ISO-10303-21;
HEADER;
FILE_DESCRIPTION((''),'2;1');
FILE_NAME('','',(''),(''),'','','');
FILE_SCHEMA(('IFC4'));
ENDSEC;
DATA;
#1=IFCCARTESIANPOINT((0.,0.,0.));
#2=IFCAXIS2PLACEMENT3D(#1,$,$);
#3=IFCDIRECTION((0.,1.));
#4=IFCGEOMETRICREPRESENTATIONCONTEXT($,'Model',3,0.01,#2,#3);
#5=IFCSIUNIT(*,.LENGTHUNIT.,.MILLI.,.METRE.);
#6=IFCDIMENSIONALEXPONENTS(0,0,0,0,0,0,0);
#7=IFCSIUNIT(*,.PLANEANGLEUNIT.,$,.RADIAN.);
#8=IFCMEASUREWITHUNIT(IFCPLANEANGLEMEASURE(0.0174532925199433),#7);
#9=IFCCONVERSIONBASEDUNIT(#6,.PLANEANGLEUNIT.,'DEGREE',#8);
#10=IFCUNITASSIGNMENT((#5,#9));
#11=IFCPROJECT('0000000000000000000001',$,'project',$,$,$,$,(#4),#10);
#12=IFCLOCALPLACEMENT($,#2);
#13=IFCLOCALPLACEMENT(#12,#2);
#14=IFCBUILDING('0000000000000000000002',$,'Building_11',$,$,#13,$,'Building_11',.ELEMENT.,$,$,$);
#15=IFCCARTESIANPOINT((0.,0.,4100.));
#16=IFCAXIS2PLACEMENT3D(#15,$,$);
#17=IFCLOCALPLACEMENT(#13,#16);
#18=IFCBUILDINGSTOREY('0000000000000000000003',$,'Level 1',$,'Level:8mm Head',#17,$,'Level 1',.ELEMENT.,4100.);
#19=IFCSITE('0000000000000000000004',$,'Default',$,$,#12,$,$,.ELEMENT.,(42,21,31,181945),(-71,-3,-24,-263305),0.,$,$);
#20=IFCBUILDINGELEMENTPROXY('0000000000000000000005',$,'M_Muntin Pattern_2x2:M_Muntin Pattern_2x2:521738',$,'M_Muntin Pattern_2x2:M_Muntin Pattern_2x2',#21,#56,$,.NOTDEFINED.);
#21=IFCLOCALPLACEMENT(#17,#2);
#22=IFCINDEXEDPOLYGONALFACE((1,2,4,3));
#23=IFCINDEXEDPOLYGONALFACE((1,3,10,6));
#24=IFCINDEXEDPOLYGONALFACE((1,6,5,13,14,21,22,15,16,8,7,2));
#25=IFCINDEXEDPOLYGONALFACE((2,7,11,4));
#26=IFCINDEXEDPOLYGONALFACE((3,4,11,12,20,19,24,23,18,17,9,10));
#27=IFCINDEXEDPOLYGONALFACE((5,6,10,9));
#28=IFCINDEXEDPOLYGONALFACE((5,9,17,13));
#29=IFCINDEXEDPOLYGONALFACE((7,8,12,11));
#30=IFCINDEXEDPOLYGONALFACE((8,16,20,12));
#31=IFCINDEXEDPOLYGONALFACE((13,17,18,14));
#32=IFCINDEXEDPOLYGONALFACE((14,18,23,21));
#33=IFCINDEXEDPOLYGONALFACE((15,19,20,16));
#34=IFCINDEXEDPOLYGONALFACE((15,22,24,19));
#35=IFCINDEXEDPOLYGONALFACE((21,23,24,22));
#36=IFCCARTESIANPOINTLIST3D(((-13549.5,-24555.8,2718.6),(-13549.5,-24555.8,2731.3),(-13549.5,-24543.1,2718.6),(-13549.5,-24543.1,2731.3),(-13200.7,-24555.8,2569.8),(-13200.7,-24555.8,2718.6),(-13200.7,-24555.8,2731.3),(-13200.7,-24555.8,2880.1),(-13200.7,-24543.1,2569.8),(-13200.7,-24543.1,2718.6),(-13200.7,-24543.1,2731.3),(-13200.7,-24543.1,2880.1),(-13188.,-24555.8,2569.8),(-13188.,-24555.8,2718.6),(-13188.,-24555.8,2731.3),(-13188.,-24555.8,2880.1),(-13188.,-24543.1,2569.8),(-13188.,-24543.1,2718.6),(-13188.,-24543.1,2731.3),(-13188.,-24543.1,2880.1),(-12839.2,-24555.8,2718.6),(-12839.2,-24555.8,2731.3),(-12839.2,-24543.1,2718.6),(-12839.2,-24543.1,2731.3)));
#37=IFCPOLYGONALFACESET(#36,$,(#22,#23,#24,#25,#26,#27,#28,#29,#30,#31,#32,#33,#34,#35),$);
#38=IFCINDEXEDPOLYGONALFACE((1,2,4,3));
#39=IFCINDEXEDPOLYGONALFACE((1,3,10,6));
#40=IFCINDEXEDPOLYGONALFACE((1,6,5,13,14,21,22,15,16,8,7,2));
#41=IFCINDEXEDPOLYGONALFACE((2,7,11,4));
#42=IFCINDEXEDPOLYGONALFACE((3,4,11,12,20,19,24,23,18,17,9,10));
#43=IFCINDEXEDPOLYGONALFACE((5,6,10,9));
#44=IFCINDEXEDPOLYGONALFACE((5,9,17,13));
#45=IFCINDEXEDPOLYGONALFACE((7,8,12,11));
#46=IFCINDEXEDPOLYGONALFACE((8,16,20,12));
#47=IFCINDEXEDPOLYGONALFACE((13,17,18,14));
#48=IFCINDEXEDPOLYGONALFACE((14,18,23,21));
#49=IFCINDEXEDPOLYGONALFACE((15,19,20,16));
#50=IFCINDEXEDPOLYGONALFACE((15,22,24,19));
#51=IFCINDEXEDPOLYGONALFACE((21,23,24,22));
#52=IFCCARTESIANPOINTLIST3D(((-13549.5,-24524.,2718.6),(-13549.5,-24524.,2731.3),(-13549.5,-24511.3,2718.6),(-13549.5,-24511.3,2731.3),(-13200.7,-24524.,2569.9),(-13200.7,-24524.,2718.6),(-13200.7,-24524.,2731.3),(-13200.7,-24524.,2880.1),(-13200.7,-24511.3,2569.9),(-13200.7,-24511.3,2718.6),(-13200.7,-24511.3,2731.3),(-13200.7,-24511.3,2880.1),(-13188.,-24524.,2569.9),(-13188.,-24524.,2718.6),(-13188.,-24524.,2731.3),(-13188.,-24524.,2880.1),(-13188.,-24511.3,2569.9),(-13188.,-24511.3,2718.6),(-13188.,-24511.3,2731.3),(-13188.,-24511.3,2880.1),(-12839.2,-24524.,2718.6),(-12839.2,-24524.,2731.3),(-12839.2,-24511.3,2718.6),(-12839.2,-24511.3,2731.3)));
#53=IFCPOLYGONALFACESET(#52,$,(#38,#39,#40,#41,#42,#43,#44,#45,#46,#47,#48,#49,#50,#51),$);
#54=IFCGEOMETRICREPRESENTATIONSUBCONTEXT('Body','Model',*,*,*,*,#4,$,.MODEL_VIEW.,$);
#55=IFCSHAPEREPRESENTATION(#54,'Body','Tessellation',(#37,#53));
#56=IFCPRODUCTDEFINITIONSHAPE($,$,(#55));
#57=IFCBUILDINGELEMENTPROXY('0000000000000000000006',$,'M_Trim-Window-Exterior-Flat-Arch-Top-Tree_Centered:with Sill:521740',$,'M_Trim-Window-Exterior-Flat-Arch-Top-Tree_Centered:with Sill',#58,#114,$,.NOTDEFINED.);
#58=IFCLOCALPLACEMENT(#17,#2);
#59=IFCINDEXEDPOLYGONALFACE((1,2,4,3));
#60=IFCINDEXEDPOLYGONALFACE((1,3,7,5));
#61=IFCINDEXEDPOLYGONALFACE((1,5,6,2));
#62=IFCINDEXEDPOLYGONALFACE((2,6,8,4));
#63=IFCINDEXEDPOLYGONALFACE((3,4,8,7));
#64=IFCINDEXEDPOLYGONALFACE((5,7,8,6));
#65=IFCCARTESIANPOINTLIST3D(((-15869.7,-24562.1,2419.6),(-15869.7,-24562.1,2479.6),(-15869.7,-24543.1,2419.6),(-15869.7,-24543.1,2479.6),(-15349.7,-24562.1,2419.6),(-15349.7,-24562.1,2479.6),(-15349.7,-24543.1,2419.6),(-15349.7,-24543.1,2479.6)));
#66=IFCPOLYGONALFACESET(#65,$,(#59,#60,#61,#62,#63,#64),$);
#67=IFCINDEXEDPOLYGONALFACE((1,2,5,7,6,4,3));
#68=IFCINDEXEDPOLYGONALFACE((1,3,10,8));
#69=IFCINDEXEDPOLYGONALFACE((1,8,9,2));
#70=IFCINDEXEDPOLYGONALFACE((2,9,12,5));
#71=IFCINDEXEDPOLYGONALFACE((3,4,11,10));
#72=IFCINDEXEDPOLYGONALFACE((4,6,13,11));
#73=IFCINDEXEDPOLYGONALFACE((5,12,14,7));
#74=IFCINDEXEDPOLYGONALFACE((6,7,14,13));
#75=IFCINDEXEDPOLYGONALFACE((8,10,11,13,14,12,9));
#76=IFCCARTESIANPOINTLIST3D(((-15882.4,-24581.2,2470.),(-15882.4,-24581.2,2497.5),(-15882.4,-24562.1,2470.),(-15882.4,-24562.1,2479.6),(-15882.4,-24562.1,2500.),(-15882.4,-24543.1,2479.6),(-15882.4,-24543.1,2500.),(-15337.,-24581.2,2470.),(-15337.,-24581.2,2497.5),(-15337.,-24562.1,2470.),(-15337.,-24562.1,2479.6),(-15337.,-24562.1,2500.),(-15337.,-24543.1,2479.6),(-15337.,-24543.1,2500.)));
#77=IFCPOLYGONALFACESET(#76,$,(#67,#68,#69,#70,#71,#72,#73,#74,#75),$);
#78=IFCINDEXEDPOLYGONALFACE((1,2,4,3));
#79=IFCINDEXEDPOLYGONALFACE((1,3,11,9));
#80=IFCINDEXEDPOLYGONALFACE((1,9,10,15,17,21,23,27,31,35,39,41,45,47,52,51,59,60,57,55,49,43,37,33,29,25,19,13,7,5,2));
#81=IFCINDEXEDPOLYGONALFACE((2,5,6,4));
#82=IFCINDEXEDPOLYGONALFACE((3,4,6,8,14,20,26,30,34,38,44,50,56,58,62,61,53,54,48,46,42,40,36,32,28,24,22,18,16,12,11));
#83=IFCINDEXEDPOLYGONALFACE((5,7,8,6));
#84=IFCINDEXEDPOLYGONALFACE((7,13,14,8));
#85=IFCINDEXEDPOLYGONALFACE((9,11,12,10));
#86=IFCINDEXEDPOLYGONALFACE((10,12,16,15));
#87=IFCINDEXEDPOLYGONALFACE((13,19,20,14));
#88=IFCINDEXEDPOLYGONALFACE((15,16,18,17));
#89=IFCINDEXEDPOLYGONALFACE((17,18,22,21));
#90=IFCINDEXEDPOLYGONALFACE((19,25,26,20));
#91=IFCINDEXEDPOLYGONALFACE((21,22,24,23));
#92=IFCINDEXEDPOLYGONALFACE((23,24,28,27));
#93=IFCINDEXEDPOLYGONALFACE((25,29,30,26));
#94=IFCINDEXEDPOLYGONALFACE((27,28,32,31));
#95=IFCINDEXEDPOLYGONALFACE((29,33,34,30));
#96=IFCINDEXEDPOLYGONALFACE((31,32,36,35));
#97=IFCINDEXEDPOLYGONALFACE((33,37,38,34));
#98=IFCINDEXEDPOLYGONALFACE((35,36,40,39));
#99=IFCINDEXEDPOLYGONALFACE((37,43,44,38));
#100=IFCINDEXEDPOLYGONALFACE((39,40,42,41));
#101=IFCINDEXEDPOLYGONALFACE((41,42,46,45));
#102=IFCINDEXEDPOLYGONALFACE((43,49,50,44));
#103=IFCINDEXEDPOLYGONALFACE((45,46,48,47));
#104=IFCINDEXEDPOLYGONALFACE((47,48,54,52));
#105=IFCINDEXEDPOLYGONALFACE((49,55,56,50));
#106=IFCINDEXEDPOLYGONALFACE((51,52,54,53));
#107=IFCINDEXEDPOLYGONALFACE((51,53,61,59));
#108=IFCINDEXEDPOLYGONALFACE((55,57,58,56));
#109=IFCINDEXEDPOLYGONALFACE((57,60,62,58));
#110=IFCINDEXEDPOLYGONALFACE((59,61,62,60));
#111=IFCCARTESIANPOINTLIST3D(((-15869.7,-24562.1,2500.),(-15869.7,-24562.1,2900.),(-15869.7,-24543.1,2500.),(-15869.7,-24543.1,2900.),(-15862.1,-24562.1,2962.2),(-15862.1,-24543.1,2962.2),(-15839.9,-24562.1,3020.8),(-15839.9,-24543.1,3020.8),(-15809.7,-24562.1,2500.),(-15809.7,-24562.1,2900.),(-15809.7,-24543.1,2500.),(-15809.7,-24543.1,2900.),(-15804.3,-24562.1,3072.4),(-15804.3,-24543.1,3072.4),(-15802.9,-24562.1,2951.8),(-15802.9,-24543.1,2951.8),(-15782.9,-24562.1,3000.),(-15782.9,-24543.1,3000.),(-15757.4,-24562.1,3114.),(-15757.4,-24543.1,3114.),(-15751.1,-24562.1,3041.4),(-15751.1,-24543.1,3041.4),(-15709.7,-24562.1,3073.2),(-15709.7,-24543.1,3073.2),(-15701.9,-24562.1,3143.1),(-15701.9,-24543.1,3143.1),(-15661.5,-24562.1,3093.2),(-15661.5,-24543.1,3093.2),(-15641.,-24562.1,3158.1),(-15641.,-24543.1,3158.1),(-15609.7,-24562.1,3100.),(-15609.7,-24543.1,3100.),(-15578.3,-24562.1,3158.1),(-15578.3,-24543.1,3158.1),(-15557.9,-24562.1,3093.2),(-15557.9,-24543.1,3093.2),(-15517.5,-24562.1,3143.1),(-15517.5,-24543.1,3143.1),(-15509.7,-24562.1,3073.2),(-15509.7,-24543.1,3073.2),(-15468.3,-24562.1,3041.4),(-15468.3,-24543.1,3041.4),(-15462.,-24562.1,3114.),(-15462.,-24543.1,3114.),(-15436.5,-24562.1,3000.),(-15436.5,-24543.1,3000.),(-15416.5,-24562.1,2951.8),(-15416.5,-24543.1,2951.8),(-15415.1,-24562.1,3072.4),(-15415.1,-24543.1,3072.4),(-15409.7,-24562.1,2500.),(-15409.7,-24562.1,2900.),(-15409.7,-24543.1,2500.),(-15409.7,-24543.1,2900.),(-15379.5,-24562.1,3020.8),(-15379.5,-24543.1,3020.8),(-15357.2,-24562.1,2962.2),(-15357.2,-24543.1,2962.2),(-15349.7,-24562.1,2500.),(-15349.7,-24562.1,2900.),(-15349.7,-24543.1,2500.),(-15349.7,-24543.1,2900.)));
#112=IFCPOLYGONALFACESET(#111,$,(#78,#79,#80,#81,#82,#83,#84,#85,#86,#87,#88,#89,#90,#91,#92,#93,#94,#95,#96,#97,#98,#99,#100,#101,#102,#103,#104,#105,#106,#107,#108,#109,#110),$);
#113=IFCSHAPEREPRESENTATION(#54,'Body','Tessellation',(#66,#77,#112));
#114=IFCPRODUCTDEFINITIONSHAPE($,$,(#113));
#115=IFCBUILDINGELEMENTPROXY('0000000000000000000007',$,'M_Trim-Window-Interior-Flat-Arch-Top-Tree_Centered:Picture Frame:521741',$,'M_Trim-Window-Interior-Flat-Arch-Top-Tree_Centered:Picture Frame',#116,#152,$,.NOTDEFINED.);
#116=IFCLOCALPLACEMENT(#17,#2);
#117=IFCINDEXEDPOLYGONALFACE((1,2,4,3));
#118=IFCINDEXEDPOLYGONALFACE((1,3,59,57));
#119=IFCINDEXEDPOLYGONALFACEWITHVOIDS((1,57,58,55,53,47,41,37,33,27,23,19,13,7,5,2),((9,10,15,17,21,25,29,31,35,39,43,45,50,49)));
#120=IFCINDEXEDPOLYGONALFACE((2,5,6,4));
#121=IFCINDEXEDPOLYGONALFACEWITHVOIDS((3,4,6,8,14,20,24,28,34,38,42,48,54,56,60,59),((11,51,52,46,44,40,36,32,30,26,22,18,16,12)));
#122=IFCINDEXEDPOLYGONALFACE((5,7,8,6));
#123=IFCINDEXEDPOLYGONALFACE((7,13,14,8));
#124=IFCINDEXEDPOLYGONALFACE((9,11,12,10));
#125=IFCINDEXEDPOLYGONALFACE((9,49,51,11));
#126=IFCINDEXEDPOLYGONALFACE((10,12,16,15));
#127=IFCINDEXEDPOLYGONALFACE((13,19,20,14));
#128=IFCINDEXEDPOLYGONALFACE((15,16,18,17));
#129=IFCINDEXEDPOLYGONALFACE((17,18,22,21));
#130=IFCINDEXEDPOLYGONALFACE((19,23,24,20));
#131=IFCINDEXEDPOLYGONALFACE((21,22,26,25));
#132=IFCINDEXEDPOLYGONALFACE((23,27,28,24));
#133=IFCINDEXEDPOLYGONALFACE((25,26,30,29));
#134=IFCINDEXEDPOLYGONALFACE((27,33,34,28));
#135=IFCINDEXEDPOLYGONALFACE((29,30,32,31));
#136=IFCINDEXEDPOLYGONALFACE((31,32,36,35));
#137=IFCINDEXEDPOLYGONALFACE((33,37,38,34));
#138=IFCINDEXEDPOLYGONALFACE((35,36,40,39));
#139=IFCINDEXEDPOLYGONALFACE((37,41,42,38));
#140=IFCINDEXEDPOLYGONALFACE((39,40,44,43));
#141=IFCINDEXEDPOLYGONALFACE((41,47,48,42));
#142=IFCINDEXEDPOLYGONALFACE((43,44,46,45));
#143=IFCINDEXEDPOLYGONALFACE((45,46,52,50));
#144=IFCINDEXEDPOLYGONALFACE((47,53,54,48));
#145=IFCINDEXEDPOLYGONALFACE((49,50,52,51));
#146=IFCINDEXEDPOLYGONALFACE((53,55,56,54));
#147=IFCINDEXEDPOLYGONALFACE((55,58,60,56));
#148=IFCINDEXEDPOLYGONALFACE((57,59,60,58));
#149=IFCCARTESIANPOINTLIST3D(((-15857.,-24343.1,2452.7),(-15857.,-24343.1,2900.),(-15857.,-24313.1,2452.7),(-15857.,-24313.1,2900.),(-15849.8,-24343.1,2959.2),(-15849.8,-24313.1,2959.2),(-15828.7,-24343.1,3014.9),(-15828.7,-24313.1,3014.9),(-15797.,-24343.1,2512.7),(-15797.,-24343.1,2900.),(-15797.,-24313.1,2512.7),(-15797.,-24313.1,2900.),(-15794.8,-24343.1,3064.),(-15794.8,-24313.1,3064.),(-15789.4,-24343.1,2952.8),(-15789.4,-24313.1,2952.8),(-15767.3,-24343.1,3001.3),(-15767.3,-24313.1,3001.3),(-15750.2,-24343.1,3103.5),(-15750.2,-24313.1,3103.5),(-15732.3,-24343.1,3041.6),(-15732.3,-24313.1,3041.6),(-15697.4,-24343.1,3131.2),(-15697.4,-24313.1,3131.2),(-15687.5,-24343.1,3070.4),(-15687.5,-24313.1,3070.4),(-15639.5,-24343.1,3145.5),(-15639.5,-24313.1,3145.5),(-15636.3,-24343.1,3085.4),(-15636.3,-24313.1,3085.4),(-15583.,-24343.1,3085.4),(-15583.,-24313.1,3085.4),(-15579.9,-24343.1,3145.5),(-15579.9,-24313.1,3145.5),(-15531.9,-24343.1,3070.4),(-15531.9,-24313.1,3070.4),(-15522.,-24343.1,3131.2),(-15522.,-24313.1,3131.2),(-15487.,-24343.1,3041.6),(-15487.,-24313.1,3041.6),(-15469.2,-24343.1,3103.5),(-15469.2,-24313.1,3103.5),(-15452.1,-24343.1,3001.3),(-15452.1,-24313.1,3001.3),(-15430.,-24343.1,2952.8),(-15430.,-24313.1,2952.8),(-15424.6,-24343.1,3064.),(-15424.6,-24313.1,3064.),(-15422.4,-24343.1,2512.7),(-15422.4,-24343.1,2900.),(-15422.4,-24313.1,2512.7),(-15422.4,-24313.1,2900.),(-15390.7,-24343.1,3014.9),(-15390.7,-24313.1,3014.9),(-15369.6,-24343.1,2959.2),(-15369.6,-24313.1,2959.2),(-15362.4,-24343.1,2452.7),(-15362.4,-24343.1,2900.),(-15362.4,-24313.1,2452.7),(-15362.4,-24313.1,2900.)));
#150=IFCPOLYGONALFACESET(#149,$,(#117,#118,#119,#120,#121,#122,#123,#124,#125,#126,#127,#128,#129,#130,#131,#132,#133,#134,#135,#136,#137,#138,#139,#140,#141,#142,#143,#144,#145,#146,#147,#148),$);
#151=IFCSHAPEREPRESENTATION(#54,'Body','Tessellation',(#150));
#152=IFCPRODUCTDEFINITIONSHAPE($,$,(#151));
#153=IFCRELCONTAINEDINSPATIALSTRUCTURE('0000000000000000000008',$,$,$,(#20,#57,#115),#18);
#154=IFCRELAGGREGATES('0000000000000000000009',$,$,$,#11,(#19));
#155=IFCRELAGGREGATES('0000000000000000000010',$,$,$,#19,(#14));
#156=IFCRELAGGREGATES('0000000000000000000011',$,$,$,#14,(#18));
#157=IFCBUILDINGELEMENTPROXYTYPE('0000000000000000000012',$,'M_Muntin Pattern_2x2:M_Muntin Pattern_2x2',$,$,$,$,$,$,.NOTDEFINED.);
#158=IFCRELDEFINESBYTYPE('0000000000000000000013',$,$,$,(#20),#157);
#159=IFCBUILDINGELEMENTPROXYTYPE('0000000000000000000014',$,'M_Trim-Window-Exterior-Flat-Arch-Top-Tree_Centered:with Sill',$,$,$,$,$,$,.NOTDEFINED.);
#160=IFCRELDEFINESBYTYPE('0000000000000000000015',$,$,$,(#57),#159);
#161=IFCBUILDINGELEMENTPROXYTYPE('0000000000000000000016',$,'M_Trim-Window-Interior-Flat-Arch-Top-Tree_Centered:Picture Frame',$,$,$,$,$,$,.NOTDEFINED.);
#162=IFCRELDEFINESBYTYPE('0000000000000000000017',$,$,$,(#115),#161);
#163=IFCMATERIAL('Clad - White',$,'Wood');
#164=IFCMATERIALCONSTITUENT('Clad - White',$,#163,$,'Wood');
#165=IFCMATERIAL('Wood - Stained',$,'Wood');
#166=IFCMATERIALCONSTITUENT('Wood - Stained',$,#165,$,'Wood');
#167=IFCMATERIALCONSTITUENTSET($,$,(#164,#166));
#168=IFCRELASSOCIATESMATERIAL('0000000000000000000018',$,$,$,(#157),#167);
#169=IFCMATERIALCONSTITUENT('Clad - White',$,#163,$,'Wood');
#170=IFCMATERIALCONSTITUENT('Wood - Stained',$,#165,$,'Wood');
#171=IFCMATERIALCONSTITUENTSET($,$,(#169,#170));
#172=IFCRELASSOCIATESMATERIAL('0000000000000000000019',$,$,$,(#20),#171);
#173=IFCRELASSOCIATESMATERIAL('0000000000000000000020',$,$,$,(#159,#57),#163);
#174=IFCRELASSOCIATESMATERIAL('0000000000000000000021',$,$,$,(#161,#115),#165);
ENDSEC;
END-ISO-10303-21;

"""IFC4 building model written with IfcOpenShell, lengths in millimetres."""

from ifc_helpers import new_model, entity, si_unit, converted_unit, direction, frame, origin, place, context, subcontext, project, spatial, line, arc, indexed_curve, outline, extrude, source, transform, mapped, material, constituent, constituent_set, type_object, type_shapes, element, save


model = new_model("IFC4")

# Units and contexts
model_context = context("Model", 3, precision=0.01, world=origin(), true_north=direction((0.0, 1.0)))
body_context = subcontext(model_context, "Body", "Model", "MODEL_VIEW")
ifc_project = project(units=[si_unit("LENGTHUNIT", "METRE", prefix="MILLI"), converted_unit("PLANEANGLEUNIT", "DEGREE", entity("IfcPlaneAngleMeasure", 0.0174532925199433), si_unit("PLANEANGLEUNIT", "RADIAN"), dimensions=[0, 0, 0, 0, 0, 0, 0])], contexts=[model_context])

# Site, building, storey
site_placement = place(None, origin())
site = spatial("IfcSite", under=ifc_project, at=site_placement, Name="Default", CompositionType="ELEMENT", RefLatitude=(42, 21, 31, 181945), RefLongitude=(-71, -3, -24, -263305), RefElevation=0.0)
building_placement = place(site_placement, origin())
building = spatial("IfcBuilding", under=site, at=building_placement, Name="Building_11", LongName="Building_11", CompositionType="ELEMENT")
storey_placement = place(building_placement, frame((0.0, 0.0, 4100.0)))
storey = spatial("IfcBuildingStorey", under=building, at=storey_placement, Name="Level 1", ObjectType="Level:8mm Head", LongName="Level 1", CompositionType="ELEMENT", Elevation=4100.0)

# Building element proxies
ifc_material_1 = material(Name="Clad - White", Category="Wood")
ifc_material_2 = material(Name="Wood - Stained", Category="Wood")
ifc_constituent_1 = constituent(ifc_material_1, Name="Clad - White", Category="Wood")
ifc_constituent_2 = constituent(ifc_material_2, Name="Wood - Stained", Category="Wood")
ifc_constituent_set_1 = constituent_set(constituents=[ifc_constituent_1, ifc_constituent_2])
ifc_constituent_3 = constituent(ifc_material_1, Name="Clad - White", Category="Wood")
ifc_constituent_4 = constituent(ifc_material_2, Name="Wood - Stained", Category="Wood")
ifc_constituent_set_2 = constituent_set(constituents=[ifc_constituent_3, ifc_constituent_4])
building_element_proxy_type_1 = type_object("IfcBuildingElementProxyType", Name="M_Muntin Pattern_2x2:M_Muntin Pattern_2x2", PredefinedType="NOTDEFINED", material=ifc_constituent_set_2)
shared_shape_1 = source(origin(), body_context, "Body", "SweptSolid", [
    extrude(outline(indexed_curve([(6.4, -6.4), (155.1, -6.4), (155.1, 6.3), (6.4, 6.3), (6.4, 355.2), (-6.3, 355.2), (-6.3, 6.3), (-155.1, 6.3), (-155.1, -6.4), (-6.3, -6.4), (-6.3, -355.1), (6.4, -355.1), (6.4, -6.4)], self_intersect=False)), frame((0.0, 9.5, 155.1), z_axis=(0.0, 1.0, 0.0), x_axis=(0.0, 0.0, 1.0)), (0.0, 0.0, 1.0), 12.7),
    extrude(outline(indexed_curve([(6.4, -6.4), (155.1, -6.4), (155.1, 6.3), (6.4, 6.3), (6.4, 355.2), (-6.3, 355.2), (-6.3, 6.3), (-155.1, 6.3), (-155.1, -6.4), (-6.3, -6.4), (-6.3, -355.1), (6.4, -355.1), (6.4, -6.4)], self_intersect=False)), frame((0.0, -22.2, 155.1), z_axis=(0.0, 1.0, 0.0), x_axis=(0.0, 0.0, 1.0)), (0.0, 0.0, 1.0), 12.7),
])
type_shapes(building_element_proxy_type_1, [shared_shape_1])
proxy_1_placement = place(storey_placement, frame((-13194.3, -24533.6, 2569.9), z_axis=(0.0, 0.0, 1.0), x_axis=(-1.0, 0.0, 0.0)))
element("IfcBuildingElementProxy", 1, at=proxy_1_placement, inside=storey, type_object=building_element_proxy_type_1, material=ifc_constituent_set_1, Name="M_Muntin Pattern_2x2:M_Muntin Pattern_2x2:521738", ObjectType="M_Muntin Pattern_2x2:M_Muntin Pattern_2x2", PredefinedType="NOTDEFINED", context=body_context, shape_type="MappedRepresentation", body=[
    mapped(shared_shape_1, transform((0.0, 0.0, 0.0), scale=1.0)),
])
building_element_proxy_type_2 = type_object("IfcBuildingElementProxyType", Name="M_Trim-Window-Exterior-Flat-Arch-Top-Tree_Centered:with Sill", PredefinedType="NOTDEFINED", material=ifc_material_1)
shared_shape_2 = source(origin(), body_context, "Body", "SweptSolid", [
    extrude(outline(indexed_curve([(-260.0, -30.0), (260.0, -30.0), (260.0, 30.0), (-260.0, 30.0), (-260.0, -30.0)], self_intersect=False)), frame((0.0, -650.4, 0.0), z_axis=(0.0, 0.0, 1.0), x_axis=(-1.0, 0.0, 0.0)), (0.0, 0.0, 1.0), 19.1),
    extrude(outline(indexed_curve([(-19.0, -15.2), (0.0, -15.2), (0.0, -5.7), (19.0, -5.7), (19.0, 14.8), (0.0, 14.8), (-19.0, 12.3), (-19.0, -15.2)], self_intersect=False)), frame((-272.7, -614.8, 19.0), z_axis=(1.0, 0.0, 0.0), x_axis=(0.0, 0.0, -1.0)), (0.0, 0.0, 1.0), 545.4),
    extrude(outline(indexed_curve([(-200.0, -260.0), (200.0, -260.0), (200.0, -200.0), (-200.0, -200.0), (-400.0, 0.0), (-200.0, 200.0), (200.0, 200.0), (200.0, 260.0), (-200.0, 260.0), (-460.0, 0.0)], segments=[line(1, 2, 3, 4), arc(4, 5, 6), line(6, 7, 8, 9), arc(9, 10, 1)], self_intersect=False)), frame((0.0, -400.0, 0.0), z_axis=(0.0, 0.0, 1.0), x_axis=(0.0, -1.0, 0.0)), (0.0, 0.0, 1.0), 19.1),
])
type_shapes(building_element_proxy_type_2, [shared_shape_2])
proxy_2_placement = place(storey_placement, frame((-15609.7, -24543.1, 3100.0), z_axis=(0.0, -1.0, 0.0), x_axis=(1.0, 0.0, 0.0)))
element("IfcBuildingElementProxy", 2, at=proxy_2_placement, inside=storey, type_object=building_element_proxy_type_2, material=ifc_material_1, Name="M_Trim-Window-Exterior-Flat-Arch-Top-Tree_Centered:with Sill:521740", ObjectType="M_Trim-Window-Exterior-Flat-Arch-Top-Tree_Centered:with Sill", PredefinedType="NOTDEFINED", context=body_context, shape_type="MappedRepresentation", body=[
    mapped(shared_shape_2, transform((0.0, 0.0, 0.0), scale=1.0)),
])
building_element_proxy_type_3 = type_object("IfcBuildingElementProxyType", Name="M_Trim-Window-Interior-Flat-Arch-Top-Tree_Centered:Picture Frame", PredefinedType="NOTDEFINED", material=ifc_material_2)
shared_shape_3 = source(origin(), body_context, "Body", "SweptSolid", [
    extrude(outline(indexed_curve([(-223.7, -247.3), (223.7, -247.3), (223.7, 247.3), (-223.7, 247.3), (-470.9, 0.0)], segments=[line(1, 2, 3, 4), arc(4, 5, 1)], self_intersect=False), holes=[indexed_curve([(-223.6, -187.3), (-411.0, 0.0), (-223.7, 187.3), (163.6, 187.3), (163.7, -187.3)], segments=[arc(1, 2, 3), line(3, 4, 5, 1)], self_intersect=False)]), frame((0.0, -423.7, 0.0), z_axis=(0.0, 0.0, 1.0), x_axis=(0.0, -1.0, 0.0)), (0.0, 0.0, 1.0), 30.0),
])
type_shapes(building_element_proxy_type_3, [shared_shape_3])
proxy_3_placement = place(storey_placement, frame((-15609.7, -24343.1, 3100.0), z_axis=(0.0, 1.0, 0.0), x_axis=(-1.0, 0.0, 0.0)))
element("IfcBuildingElementProxy", 3, at=proxy_3_placement, inside=storey, type_object=building_element_proxy_type_3, material=ifc_material_2, Name="M_Trim-Window-Interior-Flat-Arch-Top-Tree_Centered:Picture Frame:521741", ObjectType="M_Trim-Window-Interior-Flat-Arch-Top-Tree_Centered:Picture Frame", PredefinedType="NOTDEFINED", context=body_context, shape_type="MappedRepresentation", body=[
    mapped(shared_shape_3, transform((0.0, 0.0, 0.0), scale=1.0)),
])

save(model, "model.ifc")
